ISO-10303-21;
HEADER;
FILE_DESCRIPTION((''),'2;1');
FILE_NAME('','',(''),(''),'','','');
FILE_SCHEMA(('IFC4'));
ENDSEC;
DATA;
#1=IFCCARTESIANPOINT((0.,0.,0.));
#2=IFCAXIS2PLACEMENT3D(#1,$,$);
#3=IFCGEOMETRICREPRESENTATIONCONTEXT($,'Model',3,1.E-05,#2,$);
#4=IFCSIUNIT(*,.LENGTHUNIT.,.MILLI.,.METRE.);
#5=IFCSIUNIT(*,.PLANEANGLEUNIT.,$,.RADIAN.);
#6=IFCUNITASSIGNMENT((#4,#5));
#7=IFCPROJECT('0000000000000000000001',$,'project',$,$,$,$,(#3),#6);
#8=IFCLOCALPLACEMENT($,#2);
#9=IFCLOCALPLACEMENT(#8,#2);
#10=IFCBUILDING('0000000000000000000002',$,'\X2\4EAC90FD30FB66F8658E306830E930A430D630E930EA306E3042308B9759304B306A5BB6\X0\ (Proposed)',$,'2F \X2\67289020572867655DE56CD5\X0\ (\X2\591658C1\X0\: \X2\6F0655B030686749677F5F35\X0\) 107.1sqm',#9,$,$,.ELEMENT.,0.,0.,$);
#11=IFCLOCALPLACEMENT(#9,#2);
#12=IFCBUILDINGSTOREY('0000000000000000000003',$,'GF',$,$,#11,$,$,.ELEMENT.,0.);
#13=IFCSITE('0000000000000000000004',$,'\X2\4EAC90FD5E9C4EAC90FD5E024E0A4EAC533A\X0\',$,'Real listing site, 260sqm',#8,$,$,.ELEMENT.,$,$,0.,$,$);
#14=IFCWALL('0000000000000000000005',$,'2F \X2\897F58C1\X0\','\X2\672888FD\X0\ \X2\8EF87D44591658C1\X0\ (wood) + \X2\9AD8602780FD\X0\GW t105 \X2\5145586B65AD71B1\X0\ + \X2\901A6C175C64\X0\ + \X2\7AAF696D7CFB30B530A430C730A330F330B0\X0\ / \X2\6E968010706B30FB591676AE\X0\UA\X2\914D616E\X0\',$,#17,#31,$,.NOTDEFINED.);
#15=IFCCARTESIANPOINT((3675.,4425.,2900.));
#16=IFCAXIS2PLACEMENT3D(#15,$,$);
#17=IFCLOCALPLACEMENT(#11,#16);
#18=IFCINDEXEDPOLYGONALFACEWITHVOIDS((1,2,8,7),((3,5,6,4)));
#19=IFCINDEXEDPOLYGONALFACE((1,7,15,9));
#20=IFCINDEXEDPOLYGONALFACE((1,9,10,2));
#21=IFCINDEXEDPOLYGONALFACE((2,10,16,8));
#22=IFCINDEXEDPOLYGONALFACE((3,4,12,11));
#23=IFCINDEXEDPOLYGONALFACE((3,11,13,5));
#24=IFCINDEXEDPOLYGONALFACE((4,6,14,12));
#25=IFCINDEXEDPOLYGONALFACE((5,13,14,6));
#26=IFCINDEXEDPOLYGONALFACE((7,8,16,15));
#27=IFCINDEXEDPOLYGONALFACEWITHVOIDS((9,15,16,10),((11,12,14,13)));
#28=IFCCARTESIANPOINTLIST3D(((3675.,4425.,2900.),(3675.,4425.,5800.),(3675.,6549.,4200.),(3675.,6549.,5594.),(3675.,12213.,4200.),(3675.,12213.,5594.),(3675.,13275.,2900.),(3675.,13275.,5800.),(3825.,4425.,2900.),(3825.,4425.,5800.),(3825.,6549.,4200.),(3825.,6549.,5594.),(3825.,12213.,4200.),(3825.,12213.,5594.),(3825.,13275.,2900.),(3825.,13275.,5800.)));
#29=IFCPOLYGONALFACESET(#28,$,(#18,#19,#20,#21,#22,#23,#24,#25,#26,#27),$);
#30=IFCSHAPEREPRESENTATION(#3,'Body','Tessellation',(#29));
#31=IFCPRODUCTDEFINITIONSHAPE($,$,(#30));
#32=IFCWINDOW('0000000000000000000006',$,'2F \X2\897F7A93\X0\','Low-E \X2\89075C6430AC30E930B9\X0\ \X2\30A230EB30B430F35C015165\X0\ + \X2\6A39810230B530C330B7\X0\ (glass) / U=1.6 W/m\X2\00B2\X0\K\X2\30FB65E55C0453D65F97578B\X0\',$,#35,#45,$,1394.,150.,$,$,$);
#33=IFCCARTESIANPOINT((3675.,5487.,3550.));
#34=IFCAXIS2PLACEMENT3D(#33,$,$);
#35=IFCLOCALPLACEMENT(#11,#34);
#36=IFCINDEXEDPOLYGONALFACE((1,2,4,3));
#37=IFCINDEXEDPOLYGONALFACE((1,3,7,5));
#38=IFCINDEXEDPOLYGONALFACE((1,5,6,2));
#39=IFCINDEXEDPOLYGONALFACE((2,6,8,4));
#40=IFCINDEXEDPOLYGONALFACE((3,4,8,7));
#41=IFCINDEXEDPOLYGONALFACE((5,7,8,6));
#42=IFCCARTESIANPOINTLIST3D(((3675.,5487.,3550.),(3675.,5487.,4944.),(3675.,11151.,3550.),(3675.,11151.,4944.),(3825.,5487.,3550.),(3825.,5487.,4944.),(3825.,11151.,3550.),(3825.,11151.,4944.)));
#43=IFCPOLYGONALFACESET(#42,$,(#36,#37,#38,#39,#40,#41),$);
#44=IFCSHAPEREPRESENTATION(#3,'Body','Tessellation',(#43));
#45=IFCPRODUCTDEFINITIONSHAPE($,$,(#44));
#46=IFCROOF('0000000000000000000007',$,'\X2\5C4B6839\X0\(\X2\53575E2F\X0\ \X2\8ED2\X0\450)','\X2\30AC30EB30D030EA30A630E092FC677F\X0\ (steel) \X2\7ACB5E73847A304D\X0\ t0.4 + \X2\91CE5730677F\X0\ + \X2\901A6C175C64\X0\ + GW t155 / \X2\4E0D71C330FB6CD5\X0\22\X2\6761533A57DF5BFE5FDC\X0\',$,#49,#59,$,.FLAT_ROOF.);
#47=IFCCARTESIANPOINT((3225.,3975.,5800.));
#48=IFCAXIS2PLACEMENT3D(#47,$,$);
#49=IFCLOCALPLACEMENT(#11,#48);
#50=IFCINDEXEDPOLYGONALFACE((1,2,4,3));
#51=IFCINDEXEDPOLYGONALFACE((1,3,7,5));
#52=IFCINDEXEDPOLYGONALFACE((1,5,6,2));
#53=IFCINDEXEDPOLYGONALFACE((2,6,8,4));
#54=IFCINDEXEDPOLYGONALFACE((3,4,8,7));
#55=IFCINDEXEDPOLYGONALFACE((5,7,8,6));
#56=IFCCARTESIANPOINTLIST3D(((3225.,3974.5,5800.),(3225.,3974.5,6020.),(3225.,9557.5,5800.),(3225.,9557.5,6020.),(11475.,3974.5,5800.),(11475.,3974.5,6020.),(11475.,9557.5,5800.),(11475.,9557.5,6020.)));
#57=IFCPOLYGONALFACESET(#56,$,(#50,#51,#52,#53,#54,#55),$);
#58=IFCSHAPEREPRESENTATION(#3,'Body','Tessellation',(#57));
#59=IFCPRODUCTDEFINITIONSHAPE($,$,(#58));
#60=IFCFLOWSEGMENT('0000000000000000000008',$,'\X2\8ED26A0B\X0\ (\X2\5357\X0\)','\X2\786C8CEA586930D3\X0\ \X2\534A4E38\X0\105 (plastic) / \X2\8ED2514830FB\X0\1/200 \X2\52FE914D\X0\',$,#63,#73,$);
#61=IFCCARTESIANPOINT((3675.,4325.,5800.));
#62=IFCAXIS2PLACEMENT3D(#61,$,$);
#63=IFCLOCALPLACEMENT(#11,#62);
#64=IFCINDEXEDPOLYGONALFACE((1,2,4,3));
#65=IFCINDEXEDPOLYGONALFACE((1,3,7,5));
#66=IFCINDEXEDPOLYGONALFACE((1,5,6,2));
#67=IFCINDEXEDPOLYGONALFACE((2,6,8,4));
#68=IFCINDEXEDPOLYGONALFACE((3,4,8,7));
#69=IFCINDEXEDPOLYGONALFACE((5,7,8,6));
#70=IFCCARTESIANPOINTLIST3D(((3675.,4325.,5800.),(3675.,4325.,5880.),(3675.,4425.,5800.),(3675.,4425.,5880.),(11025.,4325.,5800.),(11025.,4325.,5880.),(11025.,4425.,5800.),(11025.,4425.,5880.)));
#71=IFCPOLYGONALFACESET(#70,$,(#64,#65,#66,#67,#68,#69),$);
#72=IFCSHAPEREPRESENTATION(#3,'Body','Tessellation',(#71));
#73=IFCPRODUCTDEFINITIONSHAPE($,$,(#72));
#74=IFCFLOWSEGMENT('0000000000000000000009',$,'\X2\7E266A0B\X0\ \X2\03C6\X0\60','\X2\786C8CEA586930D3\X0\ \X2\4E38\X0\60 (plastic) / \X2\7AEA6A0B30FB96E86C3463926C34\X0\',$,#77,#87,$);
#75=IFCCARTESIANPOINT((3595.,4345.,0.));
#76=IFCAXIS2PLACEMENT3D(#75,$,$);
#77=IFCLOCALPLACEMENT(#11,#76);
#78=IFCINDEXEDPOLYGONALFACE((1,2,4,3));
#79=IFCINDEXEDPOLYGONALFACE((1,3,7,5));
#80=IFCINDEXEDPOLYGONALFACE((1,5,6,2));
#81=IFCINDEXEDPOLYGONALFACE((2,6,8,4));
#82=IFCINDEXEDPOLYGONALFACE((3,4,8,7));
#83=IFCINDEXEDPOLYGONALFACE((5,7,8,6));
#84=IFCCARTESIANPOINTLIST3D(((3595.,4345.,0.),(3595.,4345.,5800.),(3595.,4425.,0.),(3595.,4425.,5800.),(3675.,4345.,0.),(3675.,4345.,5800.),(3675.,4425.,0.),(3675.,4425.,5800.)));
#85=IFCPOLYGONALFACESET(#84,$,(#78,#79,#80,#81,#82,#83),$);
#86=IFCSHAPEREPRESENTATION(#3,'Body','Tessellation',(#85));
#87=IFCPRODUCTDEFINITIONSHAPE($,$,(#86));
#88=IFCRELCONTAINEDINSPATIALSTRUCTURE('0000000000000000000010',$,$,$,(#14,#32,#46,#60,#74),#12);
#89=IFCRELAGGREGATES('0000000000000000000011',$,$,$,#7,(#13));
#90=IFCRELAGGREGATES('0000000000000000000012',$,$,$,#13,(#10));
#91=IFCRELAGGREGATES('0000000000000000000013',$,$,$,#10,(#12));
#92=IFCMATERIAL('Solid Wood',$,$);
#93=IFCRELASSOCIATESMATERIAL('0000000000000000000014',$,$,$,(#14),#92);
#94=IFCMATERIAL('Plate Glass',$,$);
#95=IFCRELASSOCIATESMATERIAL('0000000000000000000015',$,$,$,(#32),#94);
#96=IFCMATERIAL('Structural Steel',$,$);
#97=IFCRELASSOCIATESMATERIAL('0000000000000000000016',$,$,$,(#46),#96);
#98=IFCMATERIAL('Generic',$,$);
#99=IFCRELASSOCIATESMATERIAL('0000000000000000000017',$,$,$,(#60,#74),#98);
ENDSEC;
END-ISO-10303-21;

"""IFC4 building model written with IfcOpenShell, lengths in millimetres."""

from ifc_helpers import new_model, si_unit, frame, frame_2d, origin, place, context, project, spatial, rectangle, extrude, material, element, fill, save


model = new_model("IFC4")

# Units and contexts
model_context = context("Model", 3, precision=1e-05, world=origin())
ifc_project = project(units=[si_unit("LENGTHUNIT", "METRE", prefix="MILLI"), si_unit("PLANEANGLEUNIT", "RADIAN")], contexts=[model_context])

# Site, building, storey
site_placement = place(None, origin())
site = spatial("IfcSite", under=ifc_project, at=site_placement, Name="京都府京都市上京区", ObjectType="Real listing site, 260sqm", CompositionType="ELEMENT", RefElevation=0.0)
building_placement = place(site_placement, origin())
building = spatial("IfcBuilding", under=site, at=building_placement, Name="京都・書斎とライブラリのある静かな家 (Proposed)", ObjectType="2F 木造在来工法 (外壁: 漆喰と杉板張) 107.1sqm", CompositionType="ELEMENT", ElevationOfRefHeight=0.0, ElevationOfTerrain=0.0)
storey_placement = place(building_placement, origin())
storey = spatial("IfcBuildingStorey", under=building, at=storey_placement, Name="GF", CompositionType="ELEMENT", Elevation=0.0)

# Shared definitions
ifc_material_1 = material(Name="Solid Wood")

# Shared definitions
ifc_material_2 = material(Name="Plate Glass")

# Wall, opening, window
wall_1_placement = place(storey_placement, frame((3675.0, 4425.0, 2900.0)))
wall_1 = element("IfcWall", 1, at=wall_1_placement, inside=storey, material=ifc_material_1, Name="2F 西壁", Description="木製 軸組外壁 (wood) + 高性能GW t105 充填断熱 + 通気層 + 窯業系サイディング / 準耐火・外皮UA配慮", PredefinedType="NOTDEFINED", context=model_context, shape_type="SweptSolid", body=[
    extrude(rectangle(XDim=150.0, YDim=8850.0, at=frame_2d((75.0, 4425.0))), frame((3675.0, 4425.0, 2900.0)), (0.0, 0.0, 1.0), 2900.0),
])
opening_1_placement = place(storey_placement, frame((3675.0, 5487.0, 3550.0)))
opening_1 = element("IfcOpeningElement", 2, at=opening_1_placement, cuts=wall_1, PredefinedType="NOTDEFINED", context=model_context, shape_type="SweptSolid", body=[
    extrude(rectangle(XDim=150.0, YDim=5664.0, at=frame_2d((75.0, 2832.0))), frame((3675.0, 5487.0, 3550.0)), (0.0, 0.0, 1.0), 1394.0),
])
window_1_placement = place(storey_placement, frame((3675.0, 5487.0, 3550.0)))
window_1 = element("IfcWindow", 3, at=window_1_placement, inside=storey, material=ifc_material_2, Name="2F 西窓", Description="Low-E 複層ガラス アルゴン封入 + 樹脂サッシ (glass) / U=1.6 W/m²K・日射取得型", OverallHeight=1394.0, OverallWidth=150.0, context=model_context, shape_type="SweptSolid", body=[
    extrude(rectangle(XDim=150.0, YDim=5664.0, at=frame_2d((75.0, 2832.0))), frame((3675.0, 5487.0, 3550.0)), (0.0, 0.0, 1.0), 1394.0),
])
fill(opening_1, window_1)

# Roof
ifc_material_3 = material(Name="Structural Steel")
for number, where, name in (
    (4, (3225.0, 3975.0, 5800.0), "屋根(南帯 軒450)"),
):
    element("IfcRoof", number, at=place(storey_placement, frame(where)), inside=storey, material=ifc_material_3, Name=name, Description="ガルバリウム鋼板 (steel) 立平葺き t0.4 + 野地板 + 通気層 + GW t155 / 不燃・法22条区域対応", PredefinedType="FLAT_ROOF", context=model_context, shape_type="SweptSolid", body=[
        extrude(rectangle(XDim=8250.0, YDim=5583.0, at=frame_2d((4125.0, 2791.0))), frame((3225.0, 3975.0, 5800.0)), (0.0, 0.0, 1.0), 220.0),
    ])

# Flow segments
ifc_material_4 = material(Name="Generic")
flow_segment_1_placement = place(storey_placement, frame((3675.0, 4325.0, 5800.0)))
element("IfcFlowSegment", 5, at=flow_segment_1_placement, inside=storey, material=ifc_material_4, Name="軒樋 (南)", Description="硬質塩ビ 半丸105 (plastic) / 軒先・1/200 勾配", context=model_context, shape_type="SweptSolid", body=[
    extrude(rectangle(XDim=7350.0, YDim=100.0, at=frame_2d((3675.0, 50.0))), frame((3675.0, 4325.0, 5800.0)), (0.0, 0.0, 1.0), 80.0),
])
flow_segment_2_placement = place(storey_placement, frame((3595.0, 4345.0, 0.0)))
element("IfcFlowSegment", 6, at=flow_segment_2_placement, inside=storey, material=ifc_material_4, Name="縦樋 φ60", Description="硬質塩ビ 丸60 (plastic) / 竪樋・雨水排水", context=model_context, shape_type="SweptSolid", body=[
    extrude(rectangle(XDim=80.0, YDim=80.0, at=frame_2d((40.0, 40.0))), frame((3595.0, 4345.0, 0.0)), (0.0, 0.0, 1.0), 5800.0),
])

save(model, "model.ifc")
